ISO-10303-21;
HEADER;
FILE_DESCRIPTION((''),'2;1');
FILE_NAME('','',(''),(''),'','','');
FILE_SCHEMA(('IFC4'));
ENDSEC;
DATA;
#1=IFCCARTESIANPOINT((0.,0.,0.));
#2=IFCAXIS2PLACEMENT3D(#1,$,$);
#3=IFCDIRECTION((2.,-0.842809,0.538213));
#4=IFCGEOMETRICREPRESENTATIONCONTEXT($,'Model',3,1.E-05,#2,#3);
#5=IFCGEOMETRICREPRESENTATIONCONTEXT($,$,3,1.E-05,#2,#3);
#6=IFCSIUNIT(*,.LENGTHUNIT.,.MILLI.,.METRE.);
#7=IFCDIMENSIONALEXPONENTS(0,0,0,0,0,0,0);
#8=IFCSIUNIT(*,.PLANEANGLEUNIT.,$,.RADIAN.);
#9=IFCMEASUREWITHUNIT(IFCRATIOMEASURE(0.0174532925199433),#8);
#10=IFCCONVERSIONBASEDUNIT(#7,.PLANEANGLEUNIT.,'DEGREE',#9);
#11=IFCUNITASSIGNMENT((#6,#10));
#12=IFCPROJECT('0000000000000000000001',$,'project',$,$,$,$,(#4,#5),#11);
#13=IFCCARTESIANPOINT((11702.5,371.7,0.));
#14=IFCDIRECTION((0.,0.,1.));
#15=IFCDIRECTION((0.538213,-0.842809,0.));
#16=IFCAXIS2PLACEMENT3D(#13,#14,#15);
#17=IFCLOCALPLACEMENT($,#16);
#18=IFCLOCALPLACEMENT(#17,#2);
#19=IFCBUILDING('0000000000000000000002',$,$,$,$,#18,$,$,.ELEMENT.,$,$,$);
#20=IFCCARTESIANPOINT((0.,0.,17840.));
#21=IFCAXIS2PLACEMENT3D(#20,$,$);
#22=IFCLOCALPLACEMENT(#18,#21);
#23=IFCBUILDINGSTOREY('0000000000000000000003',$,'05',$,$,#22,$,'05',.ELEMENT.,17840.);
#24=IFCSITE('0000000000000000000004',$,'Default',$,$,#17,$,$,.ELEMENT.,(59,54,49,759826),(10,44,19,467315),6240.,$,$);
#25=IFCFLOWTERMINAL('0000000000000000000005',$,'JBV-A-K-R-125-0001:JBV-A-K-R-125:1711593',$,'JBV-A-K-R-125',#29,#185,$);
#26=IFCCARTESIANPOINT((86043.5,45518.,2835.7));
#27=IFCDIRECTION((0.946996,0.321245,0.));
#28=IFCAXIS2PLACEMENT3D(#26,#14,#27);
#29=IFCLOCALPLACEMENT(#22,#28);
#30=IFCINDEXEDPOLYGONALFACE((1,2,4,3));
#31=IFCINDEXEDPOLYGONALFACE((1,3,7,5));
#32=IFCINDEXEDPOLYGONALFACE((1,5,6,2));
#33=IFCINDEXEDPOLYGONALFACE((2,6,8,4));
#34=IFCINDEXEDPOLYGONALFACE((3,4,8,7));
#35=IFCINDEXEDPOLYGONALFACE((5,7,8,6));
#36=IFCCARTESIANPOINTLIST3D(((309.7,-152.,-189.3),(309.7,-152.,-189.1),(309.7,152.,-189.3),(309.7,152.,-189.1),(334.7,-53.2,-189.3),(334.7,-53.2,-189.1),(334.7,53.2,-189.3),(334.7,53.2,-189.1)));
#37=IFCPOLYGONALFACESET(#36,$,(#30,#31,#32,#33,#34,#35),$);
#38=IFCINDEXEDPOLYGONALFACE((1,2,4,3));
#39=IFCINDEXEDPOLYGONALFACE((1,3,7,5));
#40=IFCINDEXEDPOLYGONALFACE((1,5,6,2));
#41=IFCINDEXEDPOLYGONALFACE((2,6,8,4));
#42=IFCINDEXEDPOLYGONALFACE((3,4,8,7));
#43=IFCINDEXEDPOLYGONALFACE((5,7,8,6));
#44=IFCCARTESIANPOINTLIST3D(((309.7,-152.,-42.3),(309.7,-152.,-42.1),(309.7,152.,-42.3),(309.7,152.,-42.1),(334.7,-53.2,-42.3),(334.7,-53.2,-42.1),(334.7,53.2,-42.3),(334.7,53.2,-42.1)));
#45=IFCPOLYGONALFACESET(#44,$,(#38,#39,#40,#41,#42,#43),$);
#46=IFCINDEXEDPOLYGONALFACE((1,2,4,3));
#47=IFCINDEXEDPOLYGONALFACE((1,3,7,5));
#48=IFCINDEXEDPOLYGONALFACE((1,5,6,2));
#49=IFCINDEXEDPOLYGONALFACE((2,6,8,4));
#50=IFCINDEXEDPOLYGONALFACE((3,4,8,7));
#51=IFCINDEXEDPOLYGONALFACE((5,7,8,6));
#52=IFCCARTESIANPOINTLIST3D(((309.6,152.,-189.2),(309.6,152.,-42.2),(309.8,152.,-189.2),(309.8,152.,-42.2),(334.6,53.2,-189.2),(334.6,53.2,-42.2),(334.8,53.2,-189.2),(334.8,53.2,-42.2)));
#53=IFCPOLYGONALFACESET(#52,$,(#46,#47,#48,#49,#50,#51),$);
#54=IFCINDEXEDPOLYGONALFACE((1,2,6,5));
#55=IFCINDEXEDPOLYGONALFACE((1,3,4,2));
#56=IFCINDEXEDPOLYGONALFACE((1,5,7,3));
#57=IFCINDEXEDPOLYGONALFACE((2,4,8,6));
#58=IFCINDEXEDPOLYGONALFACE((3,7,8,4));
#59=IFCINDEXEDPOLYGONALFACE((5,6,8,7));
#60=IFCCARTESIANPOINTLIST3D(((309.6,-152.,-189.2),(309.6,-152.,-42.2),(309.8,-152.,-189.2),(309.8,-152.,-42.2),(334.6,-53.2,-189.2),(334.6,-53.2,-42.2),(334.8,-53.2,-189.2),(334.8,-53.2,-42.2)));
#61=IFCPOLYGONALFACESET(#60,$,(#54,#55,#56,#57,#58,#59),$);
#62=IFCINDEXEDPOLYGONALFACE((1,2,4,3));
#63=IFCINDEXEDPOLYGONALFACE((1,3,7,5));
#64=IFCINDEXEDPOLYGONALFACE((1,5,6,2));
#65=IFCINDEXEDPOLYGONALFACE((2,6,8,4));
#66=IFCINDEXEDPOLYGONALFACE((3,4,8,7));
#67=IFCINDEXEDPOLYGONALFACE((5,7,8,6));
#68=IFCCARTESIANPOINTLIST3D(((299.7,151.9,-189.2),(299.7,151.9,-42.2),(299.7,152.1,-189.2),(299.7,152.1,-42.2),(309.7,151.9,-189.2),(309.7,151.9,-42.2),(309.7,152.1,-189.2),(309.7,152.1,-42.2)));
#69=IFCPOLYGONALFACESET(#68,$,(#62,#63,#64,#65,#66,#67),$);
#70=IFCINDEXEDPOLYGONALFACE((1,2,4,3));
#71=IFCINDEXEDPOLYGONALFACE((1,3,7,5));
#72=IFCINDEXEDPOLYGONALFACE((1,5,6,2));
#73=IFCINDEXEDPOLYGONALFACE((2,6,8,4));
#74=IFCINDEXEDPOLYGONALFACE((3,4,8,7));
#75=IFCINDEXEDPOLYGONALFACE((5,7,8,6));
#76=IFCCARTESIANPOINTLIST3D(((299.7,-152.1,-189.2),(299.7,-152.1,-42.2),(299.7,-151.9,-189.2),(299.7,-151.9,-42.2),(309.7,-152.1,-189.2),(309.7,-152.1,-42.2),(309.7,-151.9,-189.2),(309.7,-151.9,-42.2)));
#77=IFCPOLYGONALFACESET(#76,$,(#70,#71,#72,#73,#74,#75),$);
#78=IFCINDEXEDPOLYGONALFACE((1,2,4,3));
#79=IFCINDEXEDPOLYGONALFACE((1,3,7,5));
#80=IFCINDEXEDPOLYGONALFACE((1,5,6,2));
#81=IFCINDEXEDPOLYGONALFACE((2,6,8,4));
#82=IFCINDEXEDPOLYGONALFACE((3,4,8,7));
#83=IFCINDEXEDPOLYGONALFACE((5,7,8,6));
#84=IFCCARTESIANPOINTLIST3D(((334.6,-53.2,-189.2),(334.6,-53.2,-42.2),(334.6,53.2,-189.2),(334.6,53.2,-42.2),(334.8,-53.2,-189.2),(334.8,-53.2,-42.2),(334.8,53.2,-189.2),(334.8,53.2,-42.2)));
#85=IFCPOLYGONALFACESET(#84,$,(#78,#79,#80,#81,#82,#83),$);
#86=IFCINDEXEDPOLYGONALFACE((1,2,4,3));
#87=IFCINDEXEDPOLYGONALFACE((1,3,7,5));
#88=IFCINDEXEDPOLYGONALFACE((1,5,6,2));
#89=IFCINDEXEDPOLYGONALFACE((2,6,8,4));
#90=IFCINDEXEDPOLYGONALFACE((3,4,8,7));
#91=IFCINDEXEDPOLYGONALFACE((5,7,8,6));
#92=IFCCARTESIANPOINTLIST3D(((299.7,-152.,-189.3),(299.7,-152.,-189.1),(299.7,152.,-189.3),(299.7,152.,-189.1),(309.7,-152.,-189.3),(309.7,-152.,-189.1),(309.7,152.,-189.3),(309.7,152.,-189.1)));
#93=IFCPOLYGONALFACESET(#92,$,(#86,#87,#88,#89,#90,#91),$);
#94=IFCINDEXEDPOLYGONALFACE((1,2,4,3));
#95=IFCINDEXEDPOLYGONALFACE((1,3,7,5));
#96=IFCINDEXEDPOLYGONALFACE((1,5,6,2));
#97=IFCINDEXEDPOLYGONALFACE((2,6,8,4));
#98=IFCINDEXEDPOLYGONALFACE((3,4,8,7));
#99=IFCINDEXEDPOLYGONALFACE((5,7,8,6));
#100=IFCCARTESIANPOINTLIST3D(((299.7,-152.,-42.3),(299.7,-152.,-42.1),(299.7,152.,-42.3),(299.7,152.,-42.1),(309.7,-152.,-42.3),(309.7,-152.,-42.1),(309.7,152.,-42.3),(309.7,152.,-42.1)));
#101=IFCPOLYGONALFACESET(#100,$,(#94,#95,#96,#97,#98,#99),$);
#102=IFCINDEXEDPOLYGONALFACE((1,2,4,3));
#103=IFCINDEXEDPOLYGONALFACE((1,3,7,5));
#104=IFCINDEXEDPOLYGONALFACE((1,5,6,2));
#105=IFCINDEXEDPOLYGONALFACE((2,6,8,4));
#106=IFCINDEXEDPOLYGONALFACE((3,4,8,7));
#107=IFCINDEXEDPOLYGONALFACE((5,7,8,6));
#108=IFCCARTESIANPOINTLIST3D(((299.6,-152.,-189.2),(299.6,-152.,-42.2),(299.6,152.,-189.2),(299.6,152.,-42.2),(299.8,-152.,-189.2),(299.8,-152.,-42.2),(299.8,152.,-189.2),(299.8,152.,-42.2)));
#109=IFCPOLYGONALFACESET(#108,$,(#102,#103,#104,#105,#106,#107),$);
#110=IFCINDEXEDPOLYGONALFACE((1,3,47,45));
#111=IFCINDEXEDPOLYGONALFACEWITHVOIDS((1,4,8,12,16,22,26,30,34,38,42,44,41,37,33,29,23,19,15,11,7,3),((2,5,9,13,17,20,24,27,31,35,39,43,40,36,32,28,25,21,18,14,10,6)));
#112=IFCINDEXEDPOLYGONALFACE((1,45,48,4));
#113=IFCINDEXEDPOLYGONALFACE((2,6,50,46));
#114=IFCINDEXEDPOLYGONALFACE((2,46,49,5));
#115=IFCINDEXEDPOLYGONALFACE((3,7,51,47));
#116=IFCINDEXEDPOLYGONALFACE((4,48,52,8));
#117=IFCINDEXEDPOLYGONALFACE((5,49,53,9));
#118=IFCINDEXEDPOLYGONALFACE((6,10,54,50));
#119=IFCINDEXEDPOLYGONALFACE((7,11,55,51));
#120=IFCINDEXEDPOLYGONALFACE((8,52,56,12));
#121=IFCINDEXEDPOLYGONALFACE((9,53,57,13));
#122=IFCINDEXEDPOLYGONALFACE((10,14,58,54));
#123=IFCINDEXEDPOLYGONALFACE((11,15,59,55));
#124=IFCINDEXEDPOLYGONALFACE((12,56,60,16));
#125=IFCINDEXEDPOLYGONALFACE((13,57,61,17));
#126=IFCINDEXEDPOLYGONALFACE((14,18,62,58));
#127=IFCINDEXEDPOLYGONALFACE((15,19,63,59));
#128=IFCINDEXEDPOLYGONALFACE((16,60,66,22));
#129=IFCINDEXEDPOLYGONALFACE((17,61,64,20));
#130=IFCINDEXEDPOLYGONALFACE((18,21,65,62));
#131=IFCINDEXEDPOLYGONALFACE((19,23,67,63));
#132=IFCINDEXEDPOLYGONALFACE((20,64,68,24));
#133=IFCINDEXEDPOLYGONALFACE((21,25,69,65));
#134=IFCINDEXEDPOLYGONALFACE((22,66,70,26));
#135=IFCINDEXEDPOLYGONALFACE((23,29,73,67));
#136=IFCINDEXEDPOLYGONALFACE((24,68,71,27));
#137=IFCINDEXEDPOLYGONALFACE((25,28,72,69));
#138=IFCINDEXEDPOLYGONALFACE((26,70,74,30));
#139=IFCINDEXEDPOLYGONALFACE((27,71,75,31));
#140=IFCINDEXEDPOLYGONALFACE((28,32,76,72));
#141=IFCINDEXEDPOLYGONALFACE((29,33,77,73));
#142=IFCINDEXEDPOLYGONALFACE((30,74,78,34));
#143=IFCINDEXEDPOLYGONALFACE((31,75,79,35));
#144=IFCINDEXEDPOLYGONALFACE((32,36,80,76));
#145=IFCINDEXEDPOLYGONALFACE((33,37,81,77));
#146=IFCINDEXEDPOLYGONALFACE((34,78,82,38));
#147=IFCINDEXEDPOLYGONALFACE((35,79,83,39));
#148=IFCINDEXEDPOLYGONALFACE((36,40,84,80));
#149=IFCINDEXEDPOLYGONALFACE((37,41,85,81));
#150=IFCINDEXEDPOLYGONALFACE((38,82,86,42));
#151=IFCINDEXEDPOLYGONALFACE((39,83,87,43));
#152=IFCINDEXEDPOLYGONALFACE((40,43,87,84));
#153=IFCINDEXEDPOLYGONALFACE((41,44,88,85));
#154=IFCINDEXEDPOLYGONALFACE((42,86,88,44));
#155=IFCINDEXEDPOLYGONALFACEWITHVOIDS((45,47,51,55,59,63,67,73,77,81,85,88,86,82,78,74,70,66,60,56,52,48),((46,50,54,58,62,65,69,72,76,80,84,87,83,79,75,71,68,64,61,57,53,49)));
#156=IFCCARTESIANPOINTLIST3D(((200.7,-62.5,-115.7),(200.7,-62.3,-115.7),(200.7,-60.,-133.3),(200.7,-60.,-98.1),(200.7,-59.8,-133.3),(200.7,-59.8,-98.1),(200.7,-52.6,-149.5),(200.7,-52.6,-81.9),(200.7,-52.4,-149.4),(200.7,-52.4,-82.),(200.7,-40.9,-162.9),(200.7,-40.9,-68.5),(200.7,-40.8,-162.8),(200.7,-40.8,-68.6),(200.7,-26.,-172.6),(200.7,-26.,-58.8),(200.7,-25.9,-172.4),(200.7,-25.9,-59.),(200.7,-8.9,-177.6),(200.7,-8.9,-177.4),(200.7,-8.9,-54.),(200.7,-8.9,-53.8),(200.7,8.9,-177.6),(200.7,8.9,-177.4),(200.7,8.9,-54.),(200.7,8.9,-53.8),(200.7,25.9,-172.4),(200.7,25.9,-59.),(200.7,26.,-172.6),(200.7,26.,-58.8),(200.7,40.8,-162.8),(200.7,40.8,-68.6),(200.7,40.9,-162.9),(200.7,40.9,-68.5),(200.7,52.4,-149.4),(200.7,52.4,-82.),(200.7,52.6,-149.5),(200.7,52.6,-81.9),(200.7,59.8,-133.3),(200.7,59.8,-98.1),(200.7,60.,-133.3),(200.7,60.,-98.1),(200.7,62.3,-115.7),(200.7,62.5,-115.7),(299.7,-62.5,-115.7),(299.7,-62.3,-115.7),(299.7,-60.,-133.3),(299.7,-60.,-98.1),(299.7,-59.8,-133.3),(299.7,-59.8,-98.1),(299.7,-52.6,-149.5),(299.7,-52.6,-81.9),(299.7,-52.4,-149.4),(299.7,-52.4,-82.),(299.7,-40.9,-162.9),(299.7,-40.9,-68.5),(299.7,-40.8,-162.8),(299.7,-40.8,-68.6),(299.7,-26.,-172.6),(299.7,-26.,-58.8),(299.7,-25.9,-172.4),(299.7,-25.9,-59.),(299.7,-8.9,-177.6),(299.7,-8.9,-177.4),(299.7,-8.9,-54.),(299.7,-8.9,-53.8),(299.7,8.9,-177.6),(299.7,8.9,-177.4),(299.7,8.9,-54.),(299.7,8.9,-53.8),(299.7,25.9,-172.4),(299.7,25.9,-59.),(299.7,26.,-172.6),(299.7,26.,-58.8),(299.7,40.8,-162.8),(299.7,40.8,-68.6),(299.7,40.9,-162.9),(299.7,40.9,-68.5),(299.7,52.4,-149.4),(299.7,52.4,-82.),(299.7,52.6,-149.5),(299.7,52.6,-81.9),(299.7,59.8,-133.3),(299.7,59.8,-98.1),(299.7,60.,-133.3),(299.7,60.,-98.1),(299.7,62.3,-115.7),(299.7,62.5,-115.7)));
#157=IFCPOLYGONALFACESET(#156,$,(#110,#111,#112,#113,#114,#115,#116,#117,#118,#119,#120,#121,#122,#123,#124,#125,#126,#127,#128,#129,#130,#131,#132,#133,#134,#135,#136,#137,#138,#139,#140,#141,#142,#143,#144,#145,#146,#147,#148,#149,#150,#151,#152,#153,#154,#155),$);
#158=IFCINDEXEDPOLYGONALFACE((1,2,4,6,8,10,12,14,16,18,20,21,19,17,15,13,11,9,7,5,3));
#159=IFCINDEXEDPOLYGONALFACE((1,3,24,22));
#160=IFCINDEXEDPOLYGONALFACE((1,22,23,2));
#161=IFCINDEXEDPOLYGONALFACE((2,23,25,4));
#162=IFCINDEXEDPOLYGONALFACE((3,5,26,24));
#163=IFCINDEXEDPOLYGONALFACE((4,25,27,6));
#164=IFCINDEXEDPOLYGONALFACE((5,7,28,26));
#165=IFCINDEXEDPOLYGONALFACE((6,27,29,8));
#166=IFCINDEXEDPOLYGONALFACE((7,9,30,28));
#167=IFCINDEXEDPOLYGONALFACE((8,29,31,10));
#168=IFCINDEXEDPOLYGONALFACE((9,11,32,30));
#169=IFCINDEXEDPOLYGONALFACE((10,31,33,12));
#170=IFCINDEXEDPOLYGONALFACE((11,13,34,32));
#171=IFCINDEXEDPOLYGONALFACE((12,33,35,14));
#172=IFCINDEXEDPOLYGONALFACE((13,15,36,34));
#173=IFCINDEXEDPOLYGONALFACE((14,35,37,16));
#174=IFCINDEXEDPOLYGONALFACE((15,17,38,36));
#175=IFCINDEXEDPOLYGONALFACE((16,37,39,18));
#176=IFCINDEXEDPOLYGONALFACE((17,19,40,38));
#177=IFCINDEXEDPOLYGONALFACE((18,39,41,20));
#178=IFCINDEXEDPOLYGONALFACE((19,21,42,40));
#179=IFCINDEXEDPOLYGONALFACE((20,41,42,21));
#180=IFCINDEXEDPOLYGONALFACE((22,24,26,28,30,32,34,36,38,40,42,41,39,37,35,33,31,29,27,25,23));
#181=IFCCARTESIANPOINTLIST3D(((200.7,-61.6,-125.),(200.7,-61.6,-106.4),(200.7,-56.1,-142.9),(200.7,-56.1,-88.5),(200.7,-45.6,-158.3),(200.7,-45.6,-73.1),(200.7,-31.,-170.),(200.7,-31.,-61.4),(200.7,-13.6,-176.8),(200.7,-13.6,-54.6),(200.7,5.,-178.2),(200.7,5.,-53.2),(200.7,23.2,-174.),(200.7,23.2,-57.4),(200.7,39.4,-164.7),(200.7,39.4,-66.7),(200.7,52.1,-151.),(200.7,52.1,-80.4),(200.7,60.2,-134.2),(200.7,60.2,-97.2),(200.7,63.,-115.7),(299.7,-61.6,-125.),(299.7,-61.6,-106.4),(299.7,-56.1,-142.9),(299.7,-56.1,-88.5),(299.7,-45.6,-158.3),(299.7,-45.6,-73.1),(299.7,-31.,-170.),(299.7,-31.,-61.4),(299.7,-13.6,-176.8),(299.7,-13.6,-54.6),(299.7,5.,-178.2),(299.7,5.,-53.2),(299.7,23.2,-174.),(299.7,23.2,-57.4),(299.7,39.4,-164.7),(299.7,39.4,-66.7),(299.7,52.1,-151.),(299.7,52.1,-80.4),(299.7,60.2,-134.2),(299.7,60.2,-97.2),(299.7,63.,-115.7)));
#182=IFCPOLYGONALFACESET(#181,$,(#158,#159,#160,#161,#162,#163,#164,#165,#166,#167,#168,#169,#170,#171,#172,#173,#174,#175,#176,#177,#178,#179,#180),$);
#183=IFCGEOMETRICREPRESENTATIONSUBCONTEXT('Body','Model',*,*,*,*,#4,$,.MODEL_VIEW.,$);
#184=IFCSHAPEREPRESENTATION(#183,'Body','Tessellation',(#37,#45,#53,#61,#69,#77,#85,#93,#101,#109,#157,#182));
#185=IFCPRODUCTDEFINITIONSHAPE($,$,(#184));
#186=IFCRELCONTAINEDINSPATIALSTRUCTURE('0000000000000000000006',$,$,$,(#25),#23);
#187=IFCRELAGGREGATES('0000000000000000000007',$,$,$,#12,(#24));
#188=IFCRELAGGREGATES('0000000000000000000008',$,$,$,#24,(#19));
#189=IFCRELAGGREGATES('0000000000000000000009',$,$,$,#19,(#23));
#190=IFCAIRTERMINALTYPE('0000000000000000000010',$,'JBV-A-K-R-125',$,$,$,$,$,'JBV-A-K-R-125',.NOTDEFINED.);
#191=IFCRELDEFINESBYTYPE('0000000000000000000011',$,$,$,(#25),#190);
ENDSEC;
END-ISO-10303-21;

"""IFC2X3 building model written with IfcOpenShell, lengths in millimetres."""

from ifc_helpers import new_model, entity, si_unit, converted_unit, direction, frame, frame_2d, origin, origin_2d_with_axis, place, context, subcontext, project, spatial, polyline, circle_curve, parameter, trimmed, segment, composite_curve, rectangle, circle, outline, extrude, source, transform, mapped, type_object, type_shapes, element, save


model = new_model("IFC2X3")

# Units and contexts
model_context = context("Model", 3, precision=1e-05, world=origin(), true_north=direction((2.0, -0.842809, 0.538213)))
context_of_model = context(None, 3, precision=1e-05, world=origin(), true_north=direction((2.0, -0.842809, 0.538213)))
body_context = subcontext(model_context, "Body", "Model", "MODEL_VIEW")
ifc_project = project(units=[si_unit("LENGTHUNIT", "METRE", prefix="MILLI"), converted_unit("PLANEANGLEUNIT", "DEGREE", entity("IfcRatioMeasure", 0.0174532925199433), si_unit("PLANEANGLEUNIT", "RADIAN"), dimensions=[0, 0, 0, 0, 0, 0, 0])], contexts=[model_context, context_of_model])

# Site, building, storey
site_placement = place(None, frame((11702.5, 371.7, 0.0), z_axis=(0.0, 0.0, 1.0), x_axis=(0.538213, -0.842809, 0.0)))
site = spatial("IfcSite", under=ifc_project, at=site_placement, Name="Default", CompositionType="ELEMENT", RefLatitude=(59, 54, 49, 759826), RefLongitude=(10, 44, 19, 467315), RefElevation=6240.0)
building_placement = place(site_placement, origin())
building = spatial("IfcBuilding", under=site, at=building_placement, CompositionType="ELEMENT")
storey_placement = place(building_placement, frame((0.0, 0.0, 17840.0)))
storey = spatial("IfcBuildingStorey", under=building, at=storey_placement, Name="05", LongName="05", CompositionType="ELEMENT", Elevation=17840.0)

# Flow terminal
air_terminal_type_1 = type_object("IfcAirTerminalType", Name="JBV-A-K-R-125", ElementType="JBV-A-K-R-125", PredefinedType="NOTDEFINED")
shared_shape_1 = source(origin(), body_context, "Body", "SweptSolid", [
    extrude(outline(polyline([(-152.0, -12.5), (152.0, -12.5), (53.2, 12.5), (-53.2, 12.5), (-152.0, -12.5)])), frame((322.2, 0.0, -189.3), z_axis=(0.0, 0.0, 1.0), x_axis=(0.0, -1.0, 0.0)), (0.0, 0.0, 1.0), 0.2),
    extrude(outline(polyline([(-152.0, -12.5), (152.0, -12.5), (53.2, 12.5), (-53.2, 12.5), (-152.0, -12.5)])), frame((322.2, 0.0, -42.3), z_axis=(0.0, 0.0, 1.0), x_axis=(0.0, -1.0, 0.0)), (0.0, 0.0, 1.0), 0.2),
    extrude(rectangle(XDim=0.2, YDim=101.9, at=frame_2d((0.0, 0.0), x_axis=(1.0, 0.0))), frame((322.2, 102.6, -189.2), z_axis=(0.0, 0.0, 1.0), x_axis=(0.969446, 0.245305, 0.0)), (0.0, 0.0, 1.0), 147.0),
    extrude(rectangle(XDim=0.2, YDim=101.9, at=frame_2d((0.0, 0.0), x_axis=(1.0, 0.0))), frame((322.2, -102.6, -189.2), z_axis=(0.0, 0.0, 1.0), x_axis=(-0.969446, 0.245305, 0.0)), (0.0, 0.0, 1.0), 147.0),
    extrude(rectangle(XDim=0.2, YDim=10.0, at=frame_2d((0.0, 0.0), x_axis=(1.0, 0.0))), frame((304.7, 152.0, -189.2), z_axis=(0.0, 0.0, 1.0), x_axis=(0.0, 1.0, 0.0)), (0.0, 0.0, 1.0), 147.0),
    extrude(rectangle(XDim=0.2, YDim=10.0, at=frame_2d((0.0, 0.0), x_axis=(1.0, 0.0))), frame((304.7, -152.0, -189.2), z_axis=(0.0, 0.0, 1.0), x_axis=(0.0, 1.0, 0.0)), (0.0, 0.0, 1.0), 147.0),
    extrude(rectangle(XDim=0.2, YDim=106.4, at=frame_2d((0.0, 0.0), x_axis=(1.0, 0.0))), frame((334.7, 0.0, -189.2)), (0.0, 0.0, 1.0), 147.0),
    extrude(rectangle(XDim=304.0, YDim=10.0, at=frame_2d((0.0, 0.0), x_axis=(1.0, 0.0))), frame((304.7, 0.0, -189.3), z_axis=(0.0, 0.0, 1.0), x_axis=(0.0, -1.0, 0.0)), (0.0, 0.0, 1.0), 0.2),
    extrude(rectangle(XDim=304.0, YDim=10.0, at=frame_2d((0.0, 0.0), x_axis=(1.0, 0.0))), frame((304.7, 0.0, -42.3), z_axis=(0.0, 0.0, 1.0), x_axis=(0.0, -1.0, 0.0)), (0.0, 0.0, 1.0), 0.2),
    extrude(rectangle(XDim=0.2, YDim=304.0, at=frame_2d((0.0, 0.0), x_axis=(1.0, 0.0))), frame((299.7, 0.0, -189.2)), (0.0, 0.0, 1.0), 147.0),
    extrude(outline(composite_curve([segment(trimmed(circle_curve(origin_2d_with_axis(), 62.5), [parameter(0.0)], [parameter(180.0)], True, "PARAMETER"), True, "CONTINUOUS"), segment(trimmed(circle_curve(origin_2d_with_axis(), 62.5), [parameter(180.0)], [parameter(360.0)], True, "PARAMETER"), True, "CONTINUOUS")], self_intersect=False), holes=[composite_curve([segment(trimmed(circle_curve(origin_2d_with_axis(), 62.3), [parameter(180.0)], [parameter(360.0)], True, "PARAMETER"), False, "CONTINUOUS"), segment(trimmed(circle_curve(origin_2d_with_axis(), 62.3), [parameter(0.0)], [parameter(180.0)], True, "PARAMETER"), False, "CONTINUOUS")], self_intersect=False)]), frame((200.7, 0.0, -115.7), z_axis=(1.0, 0.0, 0.0), x_axis=(0.0, 1.0, 0.0)), (0.0, 0.0, 1.0), 99.0),
    extrude(circle(Radius=62.6, at=frame_2d((0.0, 0.0), x_axis=(1.0, 0.0))), frame((200.7, 0.3, -115.7), z_axis=(1.0, 0.0, 0.0), x_axis=(0.0, 1.0, 0.0)), (0.0, 0.0, 1.0), 99.0),
])
type_shapes(air_terminal_type_1, [shared_shape_1])
for number, where, z_axis, x_axis, name in (
    (1, (86043.5, 45518.0, 2835.7), (0.0, 0.0, 1.0), (0.946996, 0.321245, 0.0), "JBV-A-K-R-125-0001:JBV-A-K-R-125:1711593"),
):
    element("IfcFlowTerminal", number, at=place(storey_placement, frame(where, z_axis=z_axis, x_axis=x_axis)), inside=storey, type_object=air_terminal_type_1, Name=name, ObjectType="JBV-A-K-R-125", context=body_context, shape_type="MappedRepresentation", body=[
        mapped(shared_shape_1, transform((0.0, 0.0, 0.0), scale=1.0)),
    ])

save(model, "model.ifc")
